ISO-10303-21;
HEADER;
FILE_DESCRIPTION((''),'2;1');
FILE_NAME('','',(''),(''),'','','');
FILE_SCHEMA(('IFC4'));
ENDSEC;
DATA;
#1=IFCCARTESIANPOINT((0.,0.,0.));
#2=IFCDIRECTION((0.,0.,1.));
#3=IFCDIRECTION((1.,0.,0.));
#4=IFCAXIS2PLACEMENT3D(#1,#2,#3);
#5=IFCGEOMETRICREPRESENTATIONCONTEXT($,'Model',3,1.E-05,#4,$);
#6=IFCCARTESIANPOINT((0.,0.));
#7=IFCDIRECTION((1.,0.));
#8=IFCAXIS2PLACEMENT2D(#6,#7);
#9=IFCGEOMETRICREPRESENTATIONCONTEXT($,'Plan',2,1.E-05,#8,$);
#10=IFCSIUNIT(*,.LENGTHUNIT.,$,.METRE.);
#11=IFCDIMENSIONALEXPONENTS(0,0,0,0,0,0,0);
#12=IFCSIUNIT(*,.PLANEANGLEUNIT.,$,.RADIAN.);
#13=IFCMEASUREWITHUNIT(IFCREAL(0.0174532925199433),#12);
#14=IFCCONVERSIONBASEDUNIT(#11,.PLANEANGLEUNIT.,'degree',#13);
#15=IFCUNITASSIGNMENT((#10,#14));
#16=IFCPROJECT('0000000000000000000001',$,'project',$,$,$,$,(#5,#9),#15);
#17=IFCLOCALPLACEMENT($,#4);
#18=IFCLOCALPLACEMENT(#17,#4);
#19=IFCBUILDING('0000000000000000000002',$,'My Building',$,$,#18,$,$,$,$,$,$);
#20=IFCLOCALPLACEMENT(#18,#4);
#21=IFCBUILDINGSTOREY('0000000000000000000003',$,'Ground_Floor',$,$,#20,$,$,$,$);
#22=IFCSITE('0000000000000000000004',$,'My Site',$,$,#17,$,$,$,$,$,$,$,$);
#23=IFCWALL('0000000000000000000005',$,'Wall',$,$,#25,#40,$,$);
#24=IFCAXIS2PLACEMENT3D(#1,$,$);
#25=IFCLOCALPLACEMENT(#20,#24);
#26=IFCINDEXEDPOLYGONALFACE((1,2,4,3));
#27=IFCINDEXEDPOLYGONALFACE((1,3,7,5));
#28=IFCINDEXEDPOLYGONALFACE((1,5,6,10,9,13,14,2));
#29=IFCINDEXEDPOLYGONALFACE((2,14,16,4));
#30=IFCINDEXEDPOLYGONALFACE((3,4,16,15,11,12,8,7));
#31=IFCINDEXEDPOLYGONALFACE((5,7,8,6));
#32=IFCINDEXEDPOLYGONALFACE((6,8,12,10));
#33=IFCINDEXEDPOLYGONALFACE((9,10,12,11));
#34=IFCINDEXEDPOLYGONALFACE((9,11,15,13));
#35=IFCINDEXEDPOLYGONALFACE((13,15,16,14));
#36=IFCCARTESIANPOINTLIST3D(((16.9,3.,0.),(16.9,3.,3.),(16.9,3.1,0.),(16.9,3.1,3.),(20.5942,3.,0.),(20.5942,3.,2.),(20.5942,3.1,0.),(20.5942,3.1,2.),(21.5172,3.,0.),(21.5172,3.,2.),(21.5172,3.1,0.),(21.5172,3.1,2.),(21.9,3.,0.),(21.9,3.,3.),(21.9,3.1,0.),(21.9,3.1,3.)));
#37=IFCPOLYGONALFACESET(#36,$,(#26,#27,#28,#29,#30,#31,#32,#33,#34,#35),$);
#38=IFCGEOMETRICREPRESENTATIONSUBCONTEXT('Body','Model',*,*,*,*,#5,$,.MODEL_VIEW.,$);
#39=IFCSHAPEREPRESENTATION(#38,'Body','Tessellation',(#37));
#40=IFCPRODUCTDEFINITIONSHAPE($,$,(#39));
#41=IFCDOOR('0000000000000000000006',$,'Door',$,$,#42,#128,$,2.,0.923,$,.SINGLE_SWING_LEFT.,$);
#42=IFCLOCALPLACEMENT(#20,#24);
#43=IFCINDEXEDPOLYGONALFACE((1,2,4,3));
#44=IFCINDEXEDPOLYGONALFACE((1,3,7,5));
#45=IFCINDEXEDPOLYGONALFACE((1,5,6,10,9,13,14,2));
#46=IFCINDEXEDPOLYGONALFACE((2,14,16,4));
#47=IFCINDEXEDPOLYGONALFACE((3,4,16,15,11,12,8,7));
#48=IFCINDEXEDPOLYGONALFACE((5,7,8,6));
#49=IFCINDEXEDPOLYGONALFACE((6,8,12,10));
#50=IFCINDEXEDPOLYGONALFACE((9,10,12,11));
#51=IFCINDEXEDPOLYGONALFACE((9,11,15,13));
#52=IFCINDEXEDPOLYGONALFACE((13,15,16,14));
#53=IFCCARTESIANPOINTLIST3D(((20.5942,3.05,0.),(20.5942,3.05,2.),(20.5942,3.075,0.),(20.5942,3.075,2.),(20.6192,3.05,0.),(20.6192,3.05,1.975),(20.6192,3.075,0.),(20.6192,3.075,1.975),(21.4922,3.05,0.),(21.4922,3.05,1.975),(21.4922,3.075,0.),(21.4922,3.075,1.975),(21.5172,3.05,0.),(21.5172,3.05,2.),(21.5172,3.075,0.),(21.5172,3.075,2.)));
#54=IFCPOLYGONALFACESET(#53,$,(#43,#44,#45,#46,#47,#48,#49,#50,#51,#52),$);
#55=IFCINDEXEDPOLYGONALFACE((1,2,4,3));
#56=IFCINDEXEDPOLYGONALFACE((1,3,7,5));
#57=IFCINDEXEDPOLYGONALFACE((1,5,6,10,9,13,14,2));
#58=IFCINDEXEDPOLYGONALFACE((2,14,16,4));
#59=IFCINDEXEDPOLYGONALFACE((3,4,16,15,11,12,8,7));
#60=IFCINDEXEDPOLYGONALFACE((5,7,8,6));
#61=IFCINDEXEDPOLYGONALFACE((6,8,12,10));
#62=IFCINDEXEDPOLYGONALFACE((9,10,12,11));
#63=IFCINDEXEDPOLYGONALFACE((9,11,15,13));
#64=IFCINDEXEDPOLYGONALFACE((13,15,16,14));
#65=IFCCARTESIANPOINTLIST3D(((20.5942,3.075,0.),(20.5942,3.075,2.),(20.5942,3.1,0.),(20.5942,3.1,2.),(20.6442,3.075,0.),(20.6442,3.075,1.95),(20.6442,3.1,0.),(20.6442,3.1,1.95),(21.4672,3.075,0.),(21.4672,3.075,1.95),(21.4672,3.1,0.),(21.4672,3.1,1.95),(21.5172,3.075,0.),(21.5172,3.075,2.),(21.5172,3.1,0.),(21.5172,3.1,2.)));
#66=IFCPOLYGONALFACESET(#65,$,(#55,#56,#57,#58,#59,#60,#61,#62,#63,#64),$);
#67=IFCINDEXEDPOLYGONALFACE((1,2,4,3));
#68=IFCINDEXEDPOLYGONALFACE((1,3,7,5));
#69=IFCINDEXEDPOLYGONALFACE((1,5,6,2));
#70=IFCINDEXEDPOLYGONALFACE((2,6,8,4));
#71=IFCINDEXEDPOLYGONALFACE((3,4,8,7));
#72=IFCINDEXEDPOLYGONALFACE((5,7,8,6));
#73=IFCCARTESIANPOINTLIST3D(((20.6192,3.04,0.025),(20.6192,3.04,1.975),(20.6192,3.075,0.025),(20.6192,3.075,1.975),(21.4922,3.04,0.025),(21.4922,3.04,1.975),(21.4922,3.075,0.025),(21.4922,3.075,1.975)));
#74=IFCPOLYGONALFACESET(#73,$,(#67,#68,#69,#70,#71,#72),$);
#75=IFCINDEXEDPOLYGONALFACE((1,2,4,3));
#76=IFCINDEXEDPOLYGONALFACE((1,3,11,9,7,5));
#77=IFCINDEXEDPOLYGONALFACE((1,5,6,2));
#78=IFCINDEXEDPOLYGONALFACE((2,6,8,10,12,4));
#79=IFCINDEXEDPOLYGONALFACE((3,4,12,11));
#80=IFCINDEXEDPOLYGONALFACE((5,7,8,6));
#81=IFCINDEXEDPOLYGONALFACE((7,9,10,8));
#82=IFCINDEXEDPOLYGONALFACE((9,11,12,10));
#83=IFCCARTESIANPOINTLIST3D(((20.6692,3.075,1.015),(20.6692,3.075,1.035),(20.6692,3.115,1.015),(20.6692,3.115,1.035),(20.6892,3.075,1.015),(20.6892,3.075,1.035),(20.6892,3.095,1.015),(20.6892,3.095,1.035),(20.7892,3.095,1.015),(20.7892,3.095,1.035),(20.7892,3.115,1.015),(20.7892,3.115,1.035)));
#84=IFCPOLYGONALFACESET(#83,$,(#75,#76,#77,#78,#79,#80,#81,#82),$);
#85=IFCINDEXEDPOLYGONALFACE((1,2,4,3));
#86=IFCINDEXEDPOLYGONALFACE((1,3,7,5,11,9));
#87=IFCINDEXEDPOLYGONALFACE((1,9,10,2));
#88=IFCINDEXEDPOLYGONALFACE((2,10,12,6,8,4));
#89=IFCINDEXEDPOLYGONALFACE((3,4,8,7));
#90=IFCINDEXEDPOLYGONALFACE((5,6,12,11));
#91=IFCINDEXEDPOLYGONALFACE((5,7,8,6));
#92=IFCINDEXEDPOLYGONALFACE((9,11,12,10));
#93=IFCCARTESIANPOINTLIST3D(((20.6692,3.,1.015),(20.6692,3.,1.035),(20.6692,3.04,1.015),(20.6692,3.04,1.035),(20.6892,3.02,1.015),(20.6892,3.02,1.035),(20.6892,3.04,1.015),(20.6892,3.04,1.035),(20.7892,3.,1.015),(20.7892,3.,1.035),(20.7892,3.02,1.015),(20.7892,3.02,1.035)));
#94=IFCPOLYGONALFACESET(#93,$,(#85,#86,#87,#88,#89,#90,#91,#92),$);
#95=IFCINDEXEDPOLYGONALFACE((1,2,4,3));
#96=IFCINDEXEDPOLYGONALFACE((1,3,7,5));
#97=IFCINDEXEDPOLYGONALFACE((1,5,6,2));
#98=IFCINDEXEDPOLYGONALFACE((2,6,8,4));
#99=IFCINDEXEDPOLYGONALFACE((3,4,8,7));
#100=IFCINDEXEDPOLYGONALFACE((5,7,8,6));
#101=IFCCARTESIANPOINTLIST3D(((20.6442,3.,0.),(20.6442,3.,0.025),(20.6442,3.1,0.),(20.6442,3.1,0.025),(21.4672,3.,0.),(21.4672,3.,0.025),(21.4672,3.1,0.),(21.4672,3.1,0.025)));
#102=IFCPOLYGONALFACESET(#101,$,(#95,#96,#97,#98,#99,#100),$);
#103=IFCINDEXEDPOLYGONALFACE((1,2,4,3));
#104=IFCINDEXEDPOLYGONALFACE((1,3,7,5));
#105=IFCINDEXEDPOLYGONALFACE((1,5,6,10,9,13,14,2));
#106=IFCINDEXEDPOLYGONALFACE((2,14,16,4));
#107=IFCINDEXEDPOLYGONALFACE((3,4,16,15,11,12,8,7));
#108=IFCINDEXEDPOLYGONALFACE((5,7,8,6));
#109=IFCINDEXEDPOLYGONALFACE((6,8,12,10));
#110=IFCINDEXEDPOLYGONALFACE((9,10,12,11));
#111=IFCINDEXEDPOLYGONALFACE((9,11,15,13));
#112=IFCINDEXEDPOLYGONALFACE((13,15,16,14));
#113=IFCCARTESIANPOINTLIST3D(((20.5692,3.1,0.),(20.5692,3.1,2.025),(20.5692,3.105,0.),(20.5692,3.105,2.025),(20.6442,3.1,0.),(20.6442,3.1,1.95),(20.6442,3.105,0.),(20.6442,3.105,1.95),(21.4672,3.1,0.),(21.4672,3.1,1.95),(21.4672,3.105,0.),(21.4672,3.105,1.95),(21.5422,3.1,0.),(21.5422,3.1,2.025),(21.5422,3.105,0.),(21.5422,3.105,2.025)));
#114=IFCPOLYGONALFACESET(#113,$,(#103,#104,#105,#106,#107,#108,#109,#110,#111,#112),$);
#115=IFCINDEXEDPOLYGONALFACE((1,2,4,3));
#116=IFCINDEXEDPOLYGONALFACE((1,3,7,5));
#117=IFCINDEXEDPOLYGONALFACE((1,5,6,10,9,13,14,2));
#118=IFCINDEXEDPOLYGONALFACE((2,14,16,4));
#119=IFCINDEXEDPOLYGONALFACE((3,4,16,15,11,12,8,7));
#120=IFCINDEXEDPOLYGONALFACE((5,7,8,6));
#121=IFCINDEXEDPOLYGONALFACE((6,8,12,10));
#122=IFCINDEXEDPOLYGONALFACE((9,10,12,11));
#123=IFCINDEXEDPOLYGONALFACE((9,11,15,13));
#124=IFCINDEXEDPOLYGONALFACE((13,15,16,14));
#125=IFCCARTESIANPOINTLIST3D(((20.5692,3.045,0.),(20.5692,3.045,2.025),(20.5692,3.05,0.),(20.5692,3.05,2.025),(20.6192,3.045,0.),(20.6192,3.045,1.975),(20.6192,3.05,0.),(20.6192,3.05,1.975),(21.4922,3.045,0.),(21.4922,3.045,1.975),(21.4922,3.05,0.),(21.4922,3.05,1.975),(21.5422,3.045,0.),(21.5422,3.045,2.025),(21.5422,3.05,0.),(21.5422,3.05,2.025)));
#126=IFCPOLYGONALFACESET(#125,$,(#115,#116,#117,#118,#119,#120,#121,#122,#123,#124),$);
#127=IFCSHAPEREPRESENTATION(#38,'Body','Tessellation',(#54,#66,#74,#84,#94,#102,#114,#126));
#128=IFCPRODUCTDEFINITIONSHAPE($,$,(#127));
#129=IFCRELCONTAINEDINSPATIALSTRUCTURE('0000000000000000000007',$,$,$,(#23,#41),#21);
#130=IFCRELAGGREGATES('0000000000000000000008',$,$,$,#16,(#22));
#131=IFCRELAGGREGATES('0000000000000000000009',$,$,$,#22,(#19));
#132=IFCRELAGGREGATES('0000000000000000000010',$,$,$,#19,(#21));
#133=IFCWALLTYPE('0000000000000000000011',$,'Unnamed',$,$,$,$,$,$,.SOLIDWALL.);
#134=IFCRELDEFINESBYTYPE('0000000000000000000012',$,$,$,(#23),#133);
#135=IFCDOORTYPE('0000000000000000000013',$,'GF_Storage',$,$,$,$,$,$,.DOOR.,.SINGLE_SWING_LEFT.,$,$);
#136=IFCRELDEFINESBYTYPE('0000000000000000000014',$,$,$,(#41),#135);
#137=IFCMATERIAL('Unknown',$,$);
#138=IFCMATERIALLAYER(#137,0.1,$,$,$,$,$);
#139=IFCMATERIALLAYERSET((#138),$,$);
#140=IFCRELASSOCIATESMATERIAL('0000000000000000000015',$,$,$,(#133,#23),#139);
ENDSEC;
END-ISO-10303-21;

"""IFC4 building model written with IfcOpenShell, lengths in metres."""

from ifc_helpers import new_model, entity, si_unit, converted_unit, frame, origin_with_axes, origin_2d_with_axis, place, context, subcontext, project, spatial, line, indexed_curve, outline, extrude, shape, source, transform, mapped, material, layer, layer_set, layer_usage, type_object, type_shapes, element, fill, save


model = new_model("IFC4")

# Units and contexts
model_context = context("Model", 3, precision=1e-05, world=origin_with_axes())
plan_context = context("Plan", 2, precision=1e-05, world=origin_2d_with_axis())
body_context_1 = subcontext(model_context, "Body", "Model", "MODEL_VIEW")
body_context_2 = subcontext(plan_context, "Body", "Plan", "PLAN_VIEW")
ifc_project = project(units=[si_unit("LENGTHUNIT", "METRE"), converted_unit("PLANEANGLEUNIT", "degree", entity("IfcReal", 0.0174532925199433), si_unit("PLANEANGLEUNIT", "RADIAN"), dimensions=[0, 0, 0, 0, 0, 0, 0])], contexts=[model_context, plan_context])

# Site, building, storey
site_placement = place(None, origin_with_axes())
site = spatial("IfcSite", under=ifc_project, at=site_placement, Name="My Site")
building_placement = place(site_placement, origin_with_axes())
building = spatial("IfcBuilding", under=site, at=building_placement, Name="My Building")
storey_placement = place(building_placement, origin_with_axes())
storey = spatial("IfcBuildingStorey", under=building, at=storey_placement, Name="Ground_Floor")

# Shared definitions
ifc_material = material(Name="Unknown")
ifc_layer = layer(ifc_material, 0.1)
ifc_layer_set = layer_set([ifc_layer])
wall_type = type_object("IfcWallType", Name="Unnamed", PredefinedType="SOLIDWALL", material=ifc_layer_set)

# Wall, opening, door
shared_shape_1 = source(origin_with_axes(), body_context_1, "Body", "SweptSolid", [
    extrude(outline(indexed_curve([(0.0, 0.0), (0.923, 0.0), (0.923, 2.0), (0.0, 2.0)], segments=[line(1, 2, 3, 4, 1)])), frame((0.0, -0.6, 0.0), z_axis=(0.0, -1.0, 0.0), x_axis=(1.0, 0.0, 0.0)), (0.0, 0.0, -1.0), 1.2),
])
door_type_1 = type_object("IfcDoorType", Name="GF_Storage", OperationType="SINGLE_SWING_LEFT", PredefinedType="DOOR")
shared_shape_2 = source(origin_with_axes(), body_context_1, "Body", "SweptSolid", [
    extrude(outline(indexed_curve([(0.0, 0.0), (0.0, 2.0), (0.923, 2.0), (0.923, 0.0), (0.898, 0.0), (0.898, 1.975), (0.025, 1.975), (0.025, 0.0)], segments=[line(1, 2, 3, 4, 5, 6, 7, 8, 1)])), frame((0.0, 0.025, 0.0), z_axis=(0.0, -1.0, 0.0), x_axis=(1.0, 0.0, 0.0)), (0.0, 0.0, -1.0), 0.025),
    extrude(outline(indexed_curve([(0.0, 0.0), (0.0, 2.0), (0.923, 2.0), (0.923, 0.0), (0.873, 0.0), (0.873, 1.95), (0.05, 1.95), (0.05, 0.0)], segments=[line(1, 2, 3, 4, 5, 6, 7, 8, 1)])), frame((0.0, 0.0, 0.0), z_axis=(0.0, -1.0, 0.0), x_axis=(1.0, 0.0, 0.0)), (0.0, 0.0, -1.0), 0.025),
    extrude(outline(indexed_curve([(0.0, 0.0), (0.873, 0.0), (0.873, 0.035), (0.0, 0.035)], segments=[line(1, 2, 3, 4, 1)])), frame((0.025, 0.025, 0.025), z_axis=(0.0, 0.0, 1.0), x_axis=(1.0, 0.0, 0.0)), (0.0, 0.0, 1.0), 1.95),
    extrude(outline(indexed_curve([(0.0, 0.0), (0.0, -0.04), (-0.12, -0.04), (-0.12, -0.02), (-0.02, -0.02), (-0.02, 0.0)], segments=[line(1, 2, 3, 4, 5, 6, 1)])), frame((0.848, 0.025, 1.015), z_axis=(0.0, 0.0, 1.0), x_axis=(1.0, 0.0, 0.0)), (0.0, 0.0, 1.0), 0.02),
    extrude(outline(indexed_curve([(0.0, 0.0), (0.0, 0.04), (-0.12, 0.04), (-0.12, 0.02), (-0.02, 0.02), (-0.02, 0.0)], segments=[line(1, 2, 3, 4, 5, 6, 1)])), frame((0.848, 0.06, 1.015), z_axis=(0.0, 0.0, 1.0), x_axis=(1.0, 0.0, 0.0)), (0.0, 0.0, 1.0), 0.02),
    extrude(outline(indexed_curve([(0.0, 0.0), (0.823, 0.0), (0.823, 0.1), (0.0, 0.1)], segments=[line(1, 2, 3, 4, 1)])), frame((0.05, 0.0, 0.0), z_axis=(0.0, 0.0, 1.0), x_axis=(1.0, 0.0, 0.0)), (0.0, 0.0, 1.0), 0.025),
    extrude(outline(indexed_curve([(0.0, 0.0), (0.0, 2.025), (0.973, 2.025), (0.973, 0.0), (0.898, 0.0), (0.898, 1.95), (0.075, 1.95), (0.075, 0.0)], segments=[line(1, 2, 3, 4, 5, 6, 7, 8, 1)])), frame((-0.025, -0.005, 0.0), z_axis=(0.0, -1.0, 0.0), x_axis=(1.0, 0.0, 0.0)), (0.0, 0.0, -1.0), 0.005),
    extrude(outline(indexed_curve([(0.0, 0.0), (0.0, 2.025), (0.973, 2.025), (0.973, 0.0), (0.923, 0.0), (0.923, 1.975), (0.05, 1.975), (0.05, 0.0)], segments=[line(1, 2, 3, 4, 5, 6, 7, 8, 1)])), frame((-0.025, 0.05, 0.0), z_axis=(0.0, -1.0, 0.0), x_axis=(1.0, 0.0, 0.0)), (0.0, 0.0, -1.0), 0.005),
])
shared_shape_3 = source(origin_with_axes(), body_context_2, "Body", "Curve2D", [
    entity("IfcIndexedPolyCurve", entity("IfcCartesianPointList2D", [[0.0, 0.0], [0.0, 0.05], [0.025, 0.05], [0.025, 0.025], [0.05, 0.025], [0.05, 0.0]]), [entity("IfcLineIndex", [1, 2, 3, 4, 5, 6, 1])]),
    entity("IfcIndexedPolyCurve", entity("IfcCartesianPointList2D", [[0.923, 0.0], [0.923, 0.05], [0.898, 0.05], [0.898, 0.025], [0.873, 0.025], [0.873, 0.0]]), [entity("IfcLineIndex", [1, 2, 3, 4, 5, 6, 1])]),
    entity("IfcTrimmedCurve", entity("IfcEllipse", entity("IfcAxis2Placement2D", entity("IfcCartesianPoint", [0.06, 0.05]), entity("IfcDirection", [1.0, 0.0])), 0.838, 0.873), [entity("IfcCartesianPoint", [0.898, 0.05])], [entity("IfcCartesianPoint", [0.06, 0.923])], True, "CARTESIAN"),
    entity("IfcIndexedPolyCurve", entity("IfcCartesianPointList2D", [[0.025, 0.05], [0.06, 0.05], [0.06, 0.923], [0.025, 0.923]]), [entity("IfcLineIndex", [1, 2, 3, 4, 1])]),
])
type_shapes(door_type_1, [shared_shape_2, shared_shape_3])
ifc_layer_usage_1 = layer_usage(ifc_layer_set, "AXIS2", "POSITIVE", 0.0)
wall_1_placement = place(storey_placement, frame((21.9, 3.1, 0.0), z_axis=(0.0, 0.0, 1.0), x_axis=(-1.0, 0.0, 0.0)))
wall_1 = element("IfcWall", 1, at=wall_1_placement, inside=storey, type_object=wall_type, material=ifc_layer_usage_1, Name="Wall", context=body_context_1, shape_type="SweptSolid", body=[
    extrude(outline(indexed_curve([(0.0, 0.0), (0.0, 0.1), (5.0, 0.1), (5.0, 0.0)], segments=[line(1, 2, 3, 4, 1)])), origin_with_axes(), (0.0, 0.0, 1.0), 3.0),
])
opening_1_placement = place(wall_1_placement, frame((0.3828, 0.0, 0.0), z_axis=(0.0, 0.0, 1.0), x_axis=(1.0, 0.0, 0.0)))
opening_1 = element("IfcOpeningElement", 2, at=opening_1_placement, cuts=wall_1, PredefinedType="OPENING", context=body_context_1, shape_type="MappedRepresentation", body=[
    mapped(shared_shape_1, transform((0.0, 0.0, 0.0), x_axis=(1.0, 0.0, 0.0), y_axis=(0.0, 1.0, 0.0), z_axis=(0.0, 0.0, 1.0), scale=1.0)),
])
door_1_placement = place(opening_1_placement, frame((0.0, 0.0, 0.0), z_axis=(0.0, 0.0, 1.0), x_axis=(1.0, 0.0, 0.0)))
door_1 = element("IfcDoor", 3, at=door_1_placement, inside=storey, type_object=door_type_1, Name="Door", OperationType="SINGLE_SWING_LEFT", OverallHeight=2.0, OverallWidth=0.923, shapes=[
    shape(body_context_1, "Body", "MappedRepresentation", [mapped(shared_shape_2, transform((0.0, 0.0, 0.0), x_axis=(1.0, 0.0, 0.0), y_axis=(0.0, 1.0, 0.0), z_axis=(0.0, 0.0, 1.0), scale=1.0))]),
    shape(body_context_2, "Body", "MappedRepresentation", [mapped(shared_shape_3, transform((0.0, 0.0, 0.0), x_axis=(1.0, 0.0, 0.0), y_axis=(0.0, 1.0, 0.0), z_axis=(0.0, 0.0, 1.0), scale=1.0))]),
])
fill(opening_1, door_1)

save(model, "model.ifc")
